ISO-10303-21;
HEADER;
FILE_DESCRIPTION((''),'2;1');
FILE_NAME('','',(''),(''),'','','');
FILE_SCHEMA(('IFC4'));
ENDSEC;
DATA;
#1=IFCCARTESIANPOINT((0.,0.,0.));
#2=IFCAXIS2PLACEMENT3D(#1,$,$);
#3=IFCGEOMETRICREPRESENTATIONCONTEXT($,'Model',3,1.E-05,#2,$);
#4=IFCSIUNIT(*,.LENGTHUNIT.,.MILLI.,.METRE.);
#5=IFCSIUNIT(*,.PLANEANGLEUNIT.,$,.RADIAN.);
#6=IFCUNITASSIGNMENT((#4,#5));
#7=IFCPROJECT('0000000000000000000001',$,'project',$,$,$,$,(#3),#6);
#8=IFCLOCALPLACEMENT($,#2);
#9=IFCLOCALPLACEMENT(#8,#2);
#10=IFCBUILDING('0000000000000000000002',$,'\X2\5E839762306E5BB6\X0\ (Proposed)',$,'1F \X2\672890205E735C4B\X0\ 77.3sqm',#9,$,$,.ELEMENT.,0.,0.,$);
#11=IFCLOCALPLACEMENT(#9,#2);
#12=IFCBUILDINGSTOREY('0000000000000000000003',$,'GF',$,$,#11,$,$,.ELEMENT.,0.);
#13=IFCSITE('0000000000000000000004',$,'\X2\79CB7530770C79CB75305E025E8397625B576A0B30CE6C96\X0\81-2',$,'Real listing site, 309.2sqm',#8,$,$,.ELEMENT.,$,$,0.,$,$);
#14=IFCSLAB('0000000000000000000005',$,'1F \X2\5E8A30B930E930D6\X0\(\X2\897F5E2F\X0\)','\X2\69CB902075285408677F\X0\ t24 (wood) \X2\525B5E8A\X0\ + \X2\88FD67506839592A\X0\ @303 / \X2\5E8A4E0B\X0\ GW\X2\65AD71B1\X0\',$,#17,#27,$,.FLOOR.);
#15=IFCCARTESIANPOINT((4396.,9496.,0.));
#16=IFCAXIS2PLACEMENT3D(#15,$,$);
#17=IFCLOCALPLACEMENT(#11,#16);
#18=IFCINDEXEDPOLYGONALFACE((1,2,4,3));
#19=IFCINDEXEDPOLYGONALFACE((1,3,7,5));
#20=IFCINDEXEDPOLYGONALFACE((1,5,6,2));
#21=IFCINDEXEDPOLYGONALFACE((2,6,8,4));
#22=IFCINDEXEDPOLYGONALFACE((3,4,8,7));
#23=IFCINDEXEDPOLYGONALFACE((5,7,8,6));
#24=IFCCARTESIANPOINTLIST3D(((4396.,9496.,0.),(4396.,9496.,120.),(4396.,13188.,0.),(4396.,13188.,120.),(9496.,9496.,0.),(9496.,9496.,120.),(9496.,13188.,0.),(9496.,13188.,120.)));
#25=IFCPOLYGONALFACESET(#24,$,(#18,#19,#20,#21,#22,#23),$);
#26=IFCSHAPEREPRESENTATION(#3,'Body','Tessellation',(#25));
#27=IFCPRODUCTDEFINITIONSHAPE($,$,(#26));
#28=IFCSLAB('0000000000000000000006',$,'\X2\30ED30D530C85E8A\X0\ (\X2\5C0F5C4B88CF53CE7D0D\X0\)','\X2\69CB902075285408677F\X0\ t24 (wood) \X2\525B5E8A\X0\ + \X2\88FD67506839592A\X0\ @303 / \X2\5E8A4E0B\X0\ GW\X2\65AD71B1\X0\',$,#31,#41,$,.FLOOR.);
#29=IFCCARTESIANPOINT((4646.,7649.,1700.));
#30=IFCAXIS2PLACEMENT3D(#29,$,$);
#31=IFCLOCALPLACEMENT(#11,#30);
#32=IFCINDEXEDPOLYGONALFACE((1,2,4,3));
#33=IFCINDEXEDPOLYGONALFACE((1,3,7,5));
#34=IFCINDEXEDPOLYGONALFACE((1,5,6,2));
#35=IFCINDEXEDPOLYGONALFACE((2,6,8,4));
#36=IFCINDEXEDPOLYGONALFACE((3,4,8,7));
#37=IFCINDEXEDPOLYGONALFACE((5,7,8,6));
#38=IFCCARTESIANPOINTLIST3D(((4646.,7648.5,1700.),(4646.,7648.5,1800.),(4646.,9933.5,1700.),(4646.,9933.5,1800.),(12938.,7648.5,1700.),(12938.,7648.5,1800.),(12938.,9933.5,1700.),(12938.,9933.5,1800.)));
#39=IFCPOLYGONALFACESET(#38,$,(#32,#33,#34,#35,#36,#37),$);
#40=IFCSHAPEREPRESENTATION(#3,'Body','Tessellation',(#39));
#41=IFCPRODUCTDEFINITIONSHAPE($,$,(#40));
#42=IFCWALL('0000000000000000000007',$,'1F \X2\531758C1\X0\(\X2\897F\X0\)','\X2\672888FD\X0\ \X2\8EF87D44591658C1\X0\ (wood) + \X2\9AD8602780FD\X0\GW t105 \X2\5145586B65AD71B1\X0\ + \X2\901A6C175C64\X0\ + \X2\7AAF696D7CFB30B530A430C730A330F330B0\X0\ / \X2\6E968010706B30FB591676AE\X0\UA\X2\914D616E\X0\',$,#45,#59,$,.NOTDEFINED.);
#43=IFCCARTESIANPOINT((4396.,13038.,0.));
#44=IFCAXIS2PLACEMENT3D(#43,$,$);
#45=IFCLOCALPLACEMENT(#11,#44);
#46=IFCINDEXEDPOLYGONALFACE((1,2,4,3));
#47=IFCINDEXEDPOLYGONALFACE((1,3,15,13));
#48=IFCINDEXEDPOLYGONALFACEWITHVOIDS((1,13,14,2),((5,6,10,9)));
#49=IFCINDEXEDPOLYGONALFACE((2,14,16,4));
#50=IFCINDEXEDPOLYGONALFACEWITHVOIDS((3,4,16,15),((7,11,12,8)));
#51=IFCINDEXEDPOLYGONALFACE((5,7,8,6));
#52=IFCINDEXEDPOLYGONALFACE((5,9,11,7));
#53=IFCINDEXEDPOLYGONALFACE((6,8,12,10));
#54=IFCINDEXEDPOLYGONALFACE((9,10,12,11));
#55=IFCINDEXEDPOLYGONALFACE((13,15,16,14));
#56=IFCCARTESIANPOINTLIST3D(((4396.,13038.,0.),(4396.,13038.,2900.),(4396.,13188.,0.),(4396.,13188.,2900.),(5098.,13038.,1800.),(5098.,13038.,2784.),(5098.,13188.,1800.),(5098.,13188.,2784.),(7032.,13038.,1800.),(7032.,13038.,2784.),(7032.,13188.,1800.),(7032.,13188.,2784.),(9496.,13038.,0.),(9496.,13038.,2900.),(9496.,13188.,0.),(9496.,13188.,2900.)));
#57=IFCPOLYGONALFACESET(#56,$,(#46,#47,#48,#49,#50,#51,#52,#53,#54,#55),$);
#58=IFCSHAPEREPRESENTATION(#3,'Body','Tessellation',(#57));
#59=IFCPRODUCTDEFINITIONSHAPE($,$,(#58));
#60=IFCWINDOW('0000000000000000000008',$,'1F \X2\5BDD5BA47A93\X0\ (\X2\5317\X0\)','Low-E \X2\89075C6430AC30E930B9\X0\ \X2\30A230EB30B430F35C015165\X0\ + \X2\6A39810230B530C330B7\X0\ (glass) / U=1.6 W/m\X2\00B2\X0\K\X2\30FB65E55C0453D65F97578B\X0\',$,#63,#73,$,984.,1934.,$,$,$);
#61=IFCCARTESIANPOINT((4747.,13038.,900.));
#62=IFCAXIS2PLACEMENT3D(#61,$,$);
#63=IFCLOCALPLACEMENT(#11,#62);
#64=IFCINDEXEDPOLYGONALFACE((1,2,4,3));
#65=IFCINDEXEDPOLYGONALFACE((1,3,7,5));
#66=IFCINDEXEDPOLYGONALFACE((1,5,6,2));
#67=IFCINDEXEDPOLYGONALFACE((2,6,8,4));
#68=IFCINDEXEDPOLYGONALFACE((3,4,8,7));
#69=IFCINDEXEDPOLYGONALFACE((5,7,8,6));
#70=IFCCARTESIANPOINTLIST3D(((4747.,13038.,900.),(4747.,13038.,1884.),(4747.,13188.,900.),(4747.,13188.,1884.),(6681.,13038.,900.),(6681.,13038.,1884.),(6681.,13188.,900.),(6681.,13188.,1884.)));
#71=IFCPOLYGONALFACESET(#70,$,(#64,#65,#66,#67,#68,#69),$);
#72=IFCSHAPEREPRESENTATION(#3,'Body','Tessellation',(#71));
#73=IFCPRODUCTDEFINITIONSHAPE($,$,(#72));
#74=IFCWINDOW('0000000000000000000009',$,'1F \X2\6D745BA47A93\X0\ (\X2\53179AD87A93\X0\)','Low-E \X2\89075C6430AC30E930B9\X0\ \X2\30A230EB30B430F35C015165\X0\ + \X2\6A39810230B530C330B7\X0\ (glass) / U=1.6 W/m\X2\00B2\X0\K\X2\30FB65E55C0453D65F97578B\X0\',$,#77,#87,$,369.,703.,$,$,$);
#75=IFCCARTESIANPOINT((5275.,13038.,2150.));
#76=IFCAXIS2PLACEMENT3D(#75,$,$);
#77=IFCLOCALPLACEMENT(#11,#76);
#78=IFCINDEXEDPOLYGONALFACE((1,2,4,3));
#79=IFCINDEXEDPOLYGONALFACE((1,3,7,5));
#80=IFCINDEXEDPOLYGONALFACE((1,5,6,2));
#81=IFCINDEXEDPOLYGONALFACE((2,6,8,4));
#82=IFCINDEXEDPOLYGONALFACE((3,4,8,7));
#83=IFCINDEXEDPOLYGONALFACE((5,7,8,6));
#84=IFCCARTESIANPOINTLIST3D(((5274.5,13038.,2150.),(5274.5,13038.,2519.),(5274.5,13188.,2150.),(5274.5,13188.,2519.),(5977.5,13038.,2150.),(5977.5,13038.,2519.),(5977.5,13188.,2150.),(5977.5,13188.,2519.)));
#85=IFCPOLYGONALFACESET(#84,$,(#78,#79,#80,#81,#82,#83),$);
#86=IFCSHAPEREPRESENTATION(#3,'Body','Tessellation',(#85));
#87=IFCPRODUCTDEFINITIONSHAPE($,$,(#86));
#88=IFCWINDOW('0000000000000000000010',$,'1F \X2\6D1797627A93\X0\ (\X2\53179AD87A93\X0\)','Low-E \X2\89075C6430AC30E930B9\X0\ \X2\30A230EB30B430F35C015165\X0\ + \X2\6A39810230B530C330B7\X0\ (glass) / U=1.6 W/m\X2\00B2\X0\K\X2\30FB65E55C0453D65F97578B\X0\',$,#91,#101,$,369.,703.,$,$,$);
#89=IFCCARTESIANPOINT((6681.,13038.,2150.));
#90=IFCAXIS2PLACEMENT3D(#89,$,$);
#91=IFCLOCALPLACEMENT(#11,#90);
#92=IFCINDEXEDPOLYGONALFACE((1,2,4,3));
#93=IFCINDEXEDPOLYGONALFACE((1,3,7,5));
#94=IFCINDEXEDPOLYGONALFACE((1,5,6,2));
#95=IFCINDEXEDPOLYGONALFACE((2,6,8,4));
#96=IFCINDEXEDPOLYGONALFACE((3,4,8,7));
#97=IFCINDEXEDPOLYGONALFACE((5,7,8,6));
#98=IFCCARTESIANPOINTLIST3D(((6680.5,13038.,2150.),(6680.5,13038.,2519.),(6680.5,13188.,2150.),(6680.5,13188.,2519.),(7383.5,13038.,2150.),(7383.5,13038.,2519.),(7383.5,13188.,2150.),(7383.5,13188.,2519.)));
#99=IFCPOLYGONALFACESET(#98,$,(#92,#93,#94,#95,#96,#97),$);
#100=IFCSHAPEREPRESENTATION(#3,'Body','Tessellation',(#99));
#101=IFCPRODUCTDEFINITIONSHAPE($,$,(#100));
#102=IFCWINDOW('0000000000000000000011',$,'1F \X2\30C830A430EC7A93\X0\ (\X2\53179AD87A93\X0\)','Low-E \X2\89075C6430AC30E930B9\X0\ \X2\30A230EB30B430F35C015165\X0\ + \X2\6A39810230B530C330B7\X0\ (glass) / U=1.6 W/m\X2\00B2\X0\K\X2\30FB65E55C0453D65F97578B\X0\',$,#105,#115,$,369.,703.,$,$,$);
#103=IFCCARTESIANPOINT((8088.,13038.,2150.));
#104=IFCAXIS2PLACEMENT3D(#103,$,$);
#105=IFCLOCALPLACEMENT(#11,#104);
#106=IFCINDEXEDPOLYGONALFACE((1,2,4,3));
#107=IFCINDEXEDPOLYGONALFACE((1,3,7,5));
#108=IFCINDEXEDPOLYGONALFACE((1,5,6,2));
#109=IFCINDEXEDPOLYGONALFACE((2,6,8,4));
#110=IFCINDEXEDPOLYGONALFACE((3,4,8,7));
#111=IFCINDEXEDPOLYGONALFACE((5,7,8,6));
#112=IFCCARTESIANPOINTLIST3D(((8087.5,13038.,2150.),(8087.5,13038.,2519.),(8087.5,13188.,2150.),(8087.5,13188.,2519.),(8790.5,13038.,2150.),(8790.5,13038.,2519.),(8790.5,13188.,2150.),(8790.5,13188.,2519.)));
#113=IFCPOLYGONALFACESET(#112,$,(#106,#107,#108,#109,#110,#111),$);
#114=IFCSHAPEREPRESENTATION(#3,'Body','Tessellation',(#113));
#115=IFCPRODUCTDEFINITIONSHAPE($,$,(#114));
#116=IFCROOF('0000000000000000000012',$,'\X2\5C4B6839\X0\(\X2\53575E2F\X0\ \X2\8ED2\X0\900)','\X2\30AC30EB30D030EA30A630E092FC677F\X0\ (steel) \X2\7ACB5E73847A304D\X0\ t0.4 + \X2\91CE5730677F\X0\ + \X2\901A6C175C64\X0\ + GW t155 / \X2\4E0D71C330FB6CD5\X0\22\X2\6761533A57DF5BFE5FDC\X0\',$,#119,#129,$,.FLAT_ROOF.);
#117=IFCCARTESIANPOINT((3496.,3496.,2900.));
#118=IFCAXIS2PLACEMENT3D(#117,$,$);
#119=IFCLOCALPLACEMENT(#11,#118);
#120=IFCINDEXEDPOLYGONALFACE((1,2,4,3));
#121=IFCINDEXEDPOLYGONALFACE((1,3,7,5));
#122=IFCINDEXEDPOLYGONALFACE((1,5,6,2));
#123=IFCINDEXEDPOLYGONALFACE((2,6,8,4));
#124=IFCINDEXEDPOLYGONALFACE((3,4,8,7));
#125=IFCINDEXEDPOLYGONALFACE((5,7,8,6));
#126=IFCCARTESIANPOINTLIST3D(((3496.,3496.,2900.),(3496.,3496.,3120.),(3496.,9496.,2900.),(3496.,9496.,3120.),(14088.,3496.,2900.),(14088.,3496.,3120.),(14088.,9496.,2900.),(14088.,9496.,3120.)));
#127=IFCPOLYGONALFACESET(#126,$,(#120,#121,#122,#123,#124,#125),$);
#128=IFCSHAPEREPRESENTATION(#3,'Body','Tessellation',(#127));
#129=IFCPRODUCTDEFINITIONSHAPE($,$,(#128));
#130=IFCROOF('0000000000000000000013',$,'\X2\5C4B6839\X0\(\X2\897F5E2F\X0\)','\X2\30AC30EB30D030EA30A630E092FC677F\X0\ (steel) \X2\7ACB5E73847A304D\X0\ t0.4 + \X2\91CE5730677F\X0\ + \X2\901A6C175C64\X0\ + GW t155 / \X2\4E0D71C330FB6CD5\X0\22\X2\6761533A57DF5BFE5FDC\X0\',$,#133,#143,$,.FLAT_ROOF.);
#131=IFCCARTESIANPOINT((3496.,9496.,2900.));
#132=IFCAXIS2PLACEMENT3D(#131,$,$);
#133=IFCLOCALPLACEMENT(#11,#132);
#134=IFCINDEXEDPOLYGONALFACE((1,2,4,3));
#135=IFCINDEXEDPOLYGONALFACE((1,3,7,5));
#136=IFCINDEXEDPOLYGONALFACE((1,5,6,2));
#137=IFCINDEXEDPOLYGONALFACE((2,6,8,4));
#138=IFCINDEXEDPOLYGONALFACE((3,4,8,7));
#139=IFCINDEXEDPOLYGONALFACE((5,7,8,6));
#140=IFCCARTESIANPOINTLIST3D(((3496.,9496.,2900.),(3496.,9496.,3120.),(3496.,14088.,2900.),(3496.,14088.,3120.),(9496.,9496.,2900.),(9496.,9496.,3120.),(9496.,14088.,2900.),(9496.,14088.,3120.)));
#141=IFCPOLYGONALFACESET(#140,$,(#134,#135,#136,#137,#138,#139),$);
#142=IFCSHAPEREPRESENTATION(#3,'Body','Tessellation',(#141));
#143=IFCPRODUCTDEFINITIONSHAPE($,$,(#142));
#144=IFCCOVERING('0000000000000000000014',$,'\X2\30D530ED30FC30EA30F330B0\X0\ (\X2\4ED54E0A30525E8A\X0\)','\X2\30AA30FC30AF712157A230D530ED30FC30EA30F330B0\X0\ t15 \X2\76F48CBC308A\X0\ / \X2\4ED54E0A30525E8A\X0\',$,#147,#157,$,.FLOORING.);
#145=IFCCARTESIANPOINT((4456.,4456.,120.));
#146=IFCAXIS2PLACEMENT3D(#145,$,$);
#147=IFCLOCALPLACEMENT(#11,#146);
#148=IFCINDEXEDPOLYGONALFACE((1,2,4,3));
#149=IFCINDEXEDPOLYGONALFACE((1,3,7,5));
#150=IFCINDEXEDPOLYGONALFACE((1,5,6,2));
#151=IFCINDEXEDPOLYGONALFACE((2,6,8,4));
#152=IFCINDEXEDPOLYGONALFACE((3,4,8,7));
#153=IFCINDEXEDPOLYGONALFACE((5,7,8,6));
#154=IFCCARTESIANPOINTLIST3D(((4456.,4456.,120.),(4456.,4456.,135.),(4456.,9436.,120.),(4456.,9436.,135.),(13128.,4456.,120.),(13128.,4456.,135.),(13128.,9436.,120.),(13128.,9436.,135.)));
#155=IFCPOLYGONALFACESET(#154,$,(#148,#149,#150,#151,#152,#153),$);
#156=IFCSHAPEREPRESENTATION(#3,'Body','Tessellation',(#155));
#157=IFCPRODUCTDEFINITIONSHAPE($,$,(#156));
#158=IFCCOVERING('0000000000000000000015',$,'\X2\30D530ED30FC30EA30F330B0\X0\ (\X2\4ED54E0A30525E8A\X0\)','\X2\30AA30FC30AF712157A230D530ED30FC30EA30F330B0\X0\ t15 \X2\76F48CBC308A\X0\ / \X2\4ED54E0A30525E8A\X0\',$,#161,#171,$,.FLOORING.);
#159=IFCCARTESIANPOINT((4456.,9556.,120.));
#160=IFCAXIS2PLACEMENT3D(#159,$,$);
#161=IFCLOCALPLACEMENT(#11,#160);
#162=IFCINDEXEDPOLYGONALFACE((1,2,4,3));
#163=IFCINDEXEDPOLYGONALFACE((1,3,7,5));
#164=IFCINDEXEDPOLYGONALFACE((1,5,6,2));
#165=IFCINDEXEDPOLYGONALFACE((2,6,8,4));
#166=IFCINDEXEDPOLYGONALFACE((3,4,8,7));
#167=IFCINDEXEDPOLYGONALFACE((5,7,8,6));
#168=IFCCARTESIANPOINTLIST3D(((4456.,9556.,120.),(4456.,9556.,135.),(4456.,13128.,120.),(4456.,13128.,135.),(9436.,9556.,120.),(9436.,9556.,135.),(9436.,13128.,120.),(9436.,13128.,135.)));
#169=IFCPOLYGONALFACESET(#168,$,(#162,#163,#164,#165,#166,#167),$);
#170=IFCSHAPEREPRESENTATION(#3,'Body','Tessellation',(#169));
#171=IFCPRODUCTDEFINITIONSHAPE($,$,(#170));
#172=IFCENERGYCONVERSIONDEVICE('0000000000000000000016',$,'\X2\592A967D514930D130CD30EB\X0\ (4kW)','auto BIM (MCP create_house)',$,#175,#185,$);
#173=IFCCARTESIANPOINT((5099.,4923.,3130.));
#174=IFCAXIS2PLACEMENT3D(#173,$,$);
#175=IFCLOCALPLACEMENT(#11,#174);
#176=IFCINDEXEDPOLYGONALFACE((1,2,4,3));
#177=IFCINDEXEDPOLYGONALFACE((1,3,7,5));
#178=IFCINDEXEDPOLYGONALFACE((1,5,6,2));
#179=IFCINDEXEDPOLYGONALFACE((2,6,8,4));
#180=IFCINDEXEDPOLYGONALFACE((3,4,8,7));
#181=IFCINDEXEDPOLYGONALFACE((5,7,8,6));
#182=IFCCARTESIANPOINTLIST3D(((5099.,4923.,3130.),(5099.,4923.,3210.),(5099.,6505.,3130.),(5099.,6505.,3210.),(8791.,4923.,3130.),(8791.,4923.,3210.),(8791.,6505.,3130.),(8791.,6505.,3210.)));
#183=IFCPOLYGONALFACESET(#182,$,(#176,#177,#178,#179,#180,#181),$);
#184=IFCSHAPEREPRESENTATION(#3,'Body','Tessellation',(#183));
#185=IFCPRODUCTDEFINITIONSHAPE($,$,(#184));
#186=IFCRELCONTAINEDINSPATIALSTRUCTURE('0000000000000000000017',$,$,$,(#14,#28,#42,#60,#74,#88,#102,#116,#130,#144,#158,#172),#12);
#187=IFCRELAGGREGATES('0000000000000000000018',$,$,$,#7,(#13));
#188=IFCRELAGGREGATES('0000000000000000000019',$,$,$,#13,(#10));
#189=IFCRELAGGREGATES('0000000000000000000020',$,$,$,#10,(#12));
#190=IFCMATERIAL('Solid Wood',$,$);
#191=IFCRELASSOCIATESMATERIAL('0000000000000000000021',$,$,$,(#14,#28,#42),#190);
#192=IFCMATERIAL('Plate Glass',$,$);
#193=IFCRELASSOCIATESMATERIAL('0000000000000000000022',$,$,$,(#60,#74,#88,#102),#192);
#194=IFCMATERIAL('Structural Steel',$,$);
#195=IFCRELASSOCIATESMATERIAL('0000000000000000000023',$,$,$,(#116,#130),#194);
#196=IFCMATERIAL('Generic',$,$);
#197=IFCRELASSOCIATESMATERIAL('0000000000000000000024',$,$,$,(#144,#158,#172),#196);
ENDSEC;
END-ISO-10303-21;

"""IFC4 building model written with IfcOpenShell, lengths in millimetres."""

from ifc_helpers import new_model, si_unit, frame, frame_2d, origin, place, context, project, spatial, rectangle, extrude, material, element, fill, save


model = new_model("IFC4")

# Units and contexts
model_context = context("Model", 3, precision=1e-05, world=origin())
ifc_project = project(units=[si_unit("LENGTHUNIT", "METRE", prefix="MILLI"), si_unit("PLANEANGLEUNIT", "RADIAN")], contexts=[model_context])

# Site, building, storey
site_placement = place(None, origin())
site = spatial("IfcSite", under=ifc_project, at=site_placement, Name="秋田県秋田市広面字樋ノ沖81-2", ObjectType="Real listing site, 309.2sqm", CompositionType="ELEMENT", RefElevation=0.0)
building_placement = place(site_placement, origin())
building = spatial("IfcBuilding", under=site, at=building_placement, Name="広面の家 (Proposed)", ObjectType="1F 木造平屋 77.3sqm", CompositionType="ELEMENT", ElevationOfRefHeight=0.0, ElevationOfTerrain=0.0)
storey_placement = place(building_placement, origin())
storey = spatial("IfcBuildingStorey", under=building, at=storey_placement, Name="GF", CompositionType="ELEMENT", Elevation=0.0)

# Slabs
ifc_material_1 = material(Name="Solid Wood")
slab_1_placement = place(storey_placement, frame((4396.0, 9496.0, 0.0)))
element("IfcSlab", 1, at=slab_1_placement, inside=storey, material=ifc_material_1, Name="1F 床スラブ(西帯)", Description="構造用合板 t24 (wood) 剛床 + 製材根太 @303 / 床下 GW断熱", PredefinedType="FLOOR", context=model_context, shape_type="SweptSolid", body=[
    extrude(rectangle(XDim=5100.0, YDim=3692.0, at=frame_2d((2550.0, 1846.0))), frame((4396.0, 9496.0, 0.0)), (0.0, 0.0, 1.0), 120.0),
])
slab_2_placement = place(storey_placement, frame((4646.0, 7649.0, 1700.0)))
element("IfcSlab", 2, at=slab_2_placement, inside=storey, material=ifc_material_1, Name="ロフト床 (小屋裏収納)", Description="構造用合板 t24 (wood) 剛床 + 製材根太 @303 / 床下 GW断熱", PredefinedType="FLOOR", context=model_context, shape_type="SweptSolid", body=[
    extrude(rectangle(XDim=8292.0, YDim=2285.0, at=frame_2d((4146.0, 1142.0))), frame((4646.0, 7649.0, 1700.0)), (0.0, 0.0, 1.0), 100.0),
])

# Shared definitions
ifc_material_2 = material(Name="Plate Glass")

# Wall, openings, windows
wall_1_placement = place(storey_placement, frame((4396.0, 13038.0, 0.0)))
wall_1 = element("IfcWall", 3, at=wall_1_placement, inside=storey, material=ifc_material_1, Name="1F 北壁(西)", Description="木製 軸組外壁 (wood) + 高性能GW t105 充填断熱 + 通気層 + 窯業系サイディング / 準耐火・外皮UA配慮", PredefinedType="NOTDEFINED", context=model_context, shape_type="SweptSolid", body=[
    extrude(rectangle(XDim=5100.0, YDim=150.0, at=frame_2d((2550.0, 75.0))), frame((4396.0, 13038.0, 0.0)), (0.0, 0.0, 1.0), 2900.0),
])
opening_1_placement = place(storey_placement, frame((4747.0, 13038.0, 900.0)))
opening_1 = element("IfcOpeningElement", 4, at=opening_1_placement, cuts=wall_1, PredefinedType="NOTDEFINED", context=model_context, shape_type="SweptSolid", body=[
    extrude(rectangle(XDim=1934.0, YDim=150.0, at=frame_2d((967.0, 75.0))), frame((4747.0, 13038.0, 900.0)), (0.0, 0.0, 1.0), 984.0),
])
opening_2_placement = place(storey_placement, frame((5275.0, 13038.0, 2150.0)))
opening_2 = element("IfcOpeningElement", 5, at=opening_2_placement, cuts=wall_1, PredefinedType="NOTDEFINED", context=model_context, shape_type="SweptSolid", body=[
    extrude(rectangle(XDim=703.0, YDim=150.0, at=frame_2d((351.0, 75.0))), frame((5275.0, 13038.0, 2150.0)), (0.0, 0.0, 1.0), 369.0),
])
opening_3_placement = place(storey_placement, frame((6681.0, 13038.0, 2150.0)))
opening_3 = element("IfcOpeningElement", 6, at=opening_3_placement, cuts=wall_1, PredefinedType="NOTDEFINED", context=model_context, shape_type="SweptSolid", body=[
    extrude(rectangle(XDim=703.0, YDim=150.0, at=frame_2d((351.0, 75.0))), frame((6681.0, 13038.0, 2150.0)), (0.0, 0.0, 1.0), 369.0),
])
opening_4_placement = place(storey_placement, frame((8088.0, 13038.0, 2150.0)))
opening_4 = element("IfcOpeningElement", 7, at=opening_4_placement, cuts=wall_1, PredefinedType="NOTDEFINED", context=model_context, shape_type="SweptSolid", body=[
    extrude(rectangle(XDim=703.0, YDim=150.0, at=frame_2d((351.0, 75.0))), frame((8088.0, 13038.0, 2150.0)), (0.0, 0.0, 1.0), 369.0),
])
window_1_placement = place(storey_placement, frame((4747.0, 13038.0, 900.0)))
window_1 = element("IfcWindow", 8, at=window_1_placement, inside=storey, material=ifc_material_2, Name="1F 寝室窓 (北)", Description="Low-E 複層ガラス アルゴン封入 + 樹脂サッシ (glass) / U=1.6 W/m²K・日射取得型", OverallHeight=984.0, OverallWidth=1934.0, context=model_context, shape_type="SweptSolid", body=[
    extrude(rectangle(XDim=1934.0, YDim=150.0, at=frame_2d((967.0, 75.0))), frame((4747.0, 13038.0, 900.0)), (0.0, 0.0, 1.0), 984.0),
])
fill(opening_1, window_1)
window_2_placement = place(storey_placement, frame((5275.0, 13038.0, 2150.0)))
window_2 = element("IfcWindow", 9, at=window_2_placement, inside=storey, material=ifc_material_2, Name="1F 浴室窓 (北高窓)", Description="Low-E 複層ガラス アルゴン封入 + 樹脂サッシ (glass) / U=1.6 W/m²K・日射取得型", OverallHeight=369.0, OverallWidth=703.0, context=model_context, shape_type="SweptSolid", body=[
    extrude(rectangle(XDim=703.0, YDim=150.0, at=frame_2d((351.0, 75.0))), frame((5275.0, 13038.0, 2150.0)), (0.0, 0.0, 1.0), 369.0),
])
fill(opening_2, window_2)
window_3_placement = place(storey_placement, frame((6681.0, 13038.0, 2150.0)))
window_3 = element("IfcWindow", 10, at=window_3_placement, inside=storey, material=ifc_material_2, Name="1F 洗面窓 (北高窓)", Description="Low-E 複層ガラス アルゴン封入 + 樹脂サッシ (glass) / U=1.6 W/m²K・日射取得型", OverallHeight=369.0, OverallWidth=703.0, context=model_context, shape_type="SweptSolid", body=[
    extrude(rectangle(XDim=703.0, YDim=150.0, at=frame_2d((351.0, 75.0))), frame((6681.0, 13038.0, 2150.0)), (0.0, 0.0, 1.0), 369.0),
])
fill(opening_3, window_3)
window_4_placement = place(storey_placement, frame((8088.0, 13038.0, 2150.0)))
window_4 = element("IfcWindow", 11, at=window_4_placement, inside=storey, material=ifc_material_2, Name="1F トイレ窓 (北高窓)", Description="Low-E 複層ガラス アルゴン封入 + 樹脂サッシ (glass) / U=1.6 W/m²K・日射取得型", OverallHeight=369.0, OverallWidth=703.0, context=model_context, shape_type="SweptSolid", body=[
    extrude(rectangle(XDim=703.0, YDim=150.0, at=frame_2d((351.0, 75.0))), frame((8088.0, 13038.0, 2150.0)), (0.0, 0.0, 1.0), 369.0),
])
fill(opening_4, window_4)

# Roofs
ifc_material_3 = material(Name="Structural Steel")
roof_1_placement = place(storey_placement, frame((3496.0, 3496.0, 2900.0)))
element("IfcRoof", 12, at=roof_1_placement, inside=storey, material=ifc_material_3, Name="屋根(南帯 軒900)", Description="ガルバリウム鋼板 (steel) 立平葺き t0.4 + 野地板 + 通気層 + GW t155 / 不燃・法22条区域対応", PredefinedType="FLAT_ROOF", context=model_context, shape_type="SweptSolid", body=[
    extrude(rectangle(XDim=10592.0, YDim=6000.0, at=frame_2d((5296.0, 3000.0))), frame((3496.0, 3496.0, 2900.0)), (0.0, 0.0, 1.0), 220.0),
])
roof_2_placement = place(storey_placement, frame((3496.0, 9496.0, 2900.0)))
element("IfcRoof", 13, at=roof_2_placement, inside=storey, material=ifc_material_3, Name="屋根(西帯)", Description="ガルバリウム鋼板 (steel) 立平葺き t0.4 + 野地板 + 通気層 + GW t155 / 不燃・法22条区域対応", PredefinedType="FLAT_ROOF", context=model_context, shape_type="SweptSolid", body=[
    extrude(rectangle(XDim=6000.0, YDim=4592.0, at=frame_2d((3000.0, 2296.0))), frame((3496.0, 9496.0, 2900.0)), (0.0, 0.0, 1.0), 220.0),
])

# Coverings
ifc_material_4 = material(Name="Generic")
covering_1_placement = place(storey_placement, frame((4456.0, 4456.0, 120.0)))
element("IfcCovering", 14, at=covering_1_placement, inside=storey, material=ifc_material_4, Name="フローリング (仕上げ床)", Description="オーク無垢フローリング t15 直貼り / 仕上げ床", PredefinedType="FLOORING", context=model_context, shape_type="SweptSolid", body=[
    extrude(rectangle(XDim=8672.0, YDim=4980.0, at=frame_2d((4336.0, 2490.0))), frame((4456.0, 4456.0, 120.0)), (0.0, 0.0, 1.0), 15.0),
])
covering_2_placement = place(storey_placement, frame((4456.0, 9556.0, 120.0)))
element("IfcCovering", 15, at=covering_2_placement, inside=storey, material=ifc_material_4, Name="フローリング (仕上げ床)", Description="オーク無垢フローリング t15 直貼り / 仕上げ床", PredefinedType="FLOORING", context=model_context, shape_type="SweptSolid", body=[
    extrude(rectangle(XDim=4980.0, YDim=3572.0, at=frame_2d((2490.0, 1786.0))), frame((4456.0, 9556.0, 120.0)), (0.0, 0.0, 1.0), 15.0),
])

# Energy conversion device
energy_conversion_device_placement = place(storey_placement, frame((5099.0, 4923.0, 3130.0)))
element("IfcEnergyConversionDevice", 16, at=energy_conversion_device_placement, inside=storey, material=ifc_material_4, Name="太陽光パネル (4kW)", Description="auto BIM (MCP create_house)", context=model_context, shape_type="SweptSolid", body=[
    extrude(rectangle(XDim=3692.0, YDim=1582.0, at=frame_2d((1846.0, 791.0))), frame((5099.0, 4923.0, 3130.0)), (0.0, 0.0, 1.0), 80.0),
])

save(model, "model.ifc")
